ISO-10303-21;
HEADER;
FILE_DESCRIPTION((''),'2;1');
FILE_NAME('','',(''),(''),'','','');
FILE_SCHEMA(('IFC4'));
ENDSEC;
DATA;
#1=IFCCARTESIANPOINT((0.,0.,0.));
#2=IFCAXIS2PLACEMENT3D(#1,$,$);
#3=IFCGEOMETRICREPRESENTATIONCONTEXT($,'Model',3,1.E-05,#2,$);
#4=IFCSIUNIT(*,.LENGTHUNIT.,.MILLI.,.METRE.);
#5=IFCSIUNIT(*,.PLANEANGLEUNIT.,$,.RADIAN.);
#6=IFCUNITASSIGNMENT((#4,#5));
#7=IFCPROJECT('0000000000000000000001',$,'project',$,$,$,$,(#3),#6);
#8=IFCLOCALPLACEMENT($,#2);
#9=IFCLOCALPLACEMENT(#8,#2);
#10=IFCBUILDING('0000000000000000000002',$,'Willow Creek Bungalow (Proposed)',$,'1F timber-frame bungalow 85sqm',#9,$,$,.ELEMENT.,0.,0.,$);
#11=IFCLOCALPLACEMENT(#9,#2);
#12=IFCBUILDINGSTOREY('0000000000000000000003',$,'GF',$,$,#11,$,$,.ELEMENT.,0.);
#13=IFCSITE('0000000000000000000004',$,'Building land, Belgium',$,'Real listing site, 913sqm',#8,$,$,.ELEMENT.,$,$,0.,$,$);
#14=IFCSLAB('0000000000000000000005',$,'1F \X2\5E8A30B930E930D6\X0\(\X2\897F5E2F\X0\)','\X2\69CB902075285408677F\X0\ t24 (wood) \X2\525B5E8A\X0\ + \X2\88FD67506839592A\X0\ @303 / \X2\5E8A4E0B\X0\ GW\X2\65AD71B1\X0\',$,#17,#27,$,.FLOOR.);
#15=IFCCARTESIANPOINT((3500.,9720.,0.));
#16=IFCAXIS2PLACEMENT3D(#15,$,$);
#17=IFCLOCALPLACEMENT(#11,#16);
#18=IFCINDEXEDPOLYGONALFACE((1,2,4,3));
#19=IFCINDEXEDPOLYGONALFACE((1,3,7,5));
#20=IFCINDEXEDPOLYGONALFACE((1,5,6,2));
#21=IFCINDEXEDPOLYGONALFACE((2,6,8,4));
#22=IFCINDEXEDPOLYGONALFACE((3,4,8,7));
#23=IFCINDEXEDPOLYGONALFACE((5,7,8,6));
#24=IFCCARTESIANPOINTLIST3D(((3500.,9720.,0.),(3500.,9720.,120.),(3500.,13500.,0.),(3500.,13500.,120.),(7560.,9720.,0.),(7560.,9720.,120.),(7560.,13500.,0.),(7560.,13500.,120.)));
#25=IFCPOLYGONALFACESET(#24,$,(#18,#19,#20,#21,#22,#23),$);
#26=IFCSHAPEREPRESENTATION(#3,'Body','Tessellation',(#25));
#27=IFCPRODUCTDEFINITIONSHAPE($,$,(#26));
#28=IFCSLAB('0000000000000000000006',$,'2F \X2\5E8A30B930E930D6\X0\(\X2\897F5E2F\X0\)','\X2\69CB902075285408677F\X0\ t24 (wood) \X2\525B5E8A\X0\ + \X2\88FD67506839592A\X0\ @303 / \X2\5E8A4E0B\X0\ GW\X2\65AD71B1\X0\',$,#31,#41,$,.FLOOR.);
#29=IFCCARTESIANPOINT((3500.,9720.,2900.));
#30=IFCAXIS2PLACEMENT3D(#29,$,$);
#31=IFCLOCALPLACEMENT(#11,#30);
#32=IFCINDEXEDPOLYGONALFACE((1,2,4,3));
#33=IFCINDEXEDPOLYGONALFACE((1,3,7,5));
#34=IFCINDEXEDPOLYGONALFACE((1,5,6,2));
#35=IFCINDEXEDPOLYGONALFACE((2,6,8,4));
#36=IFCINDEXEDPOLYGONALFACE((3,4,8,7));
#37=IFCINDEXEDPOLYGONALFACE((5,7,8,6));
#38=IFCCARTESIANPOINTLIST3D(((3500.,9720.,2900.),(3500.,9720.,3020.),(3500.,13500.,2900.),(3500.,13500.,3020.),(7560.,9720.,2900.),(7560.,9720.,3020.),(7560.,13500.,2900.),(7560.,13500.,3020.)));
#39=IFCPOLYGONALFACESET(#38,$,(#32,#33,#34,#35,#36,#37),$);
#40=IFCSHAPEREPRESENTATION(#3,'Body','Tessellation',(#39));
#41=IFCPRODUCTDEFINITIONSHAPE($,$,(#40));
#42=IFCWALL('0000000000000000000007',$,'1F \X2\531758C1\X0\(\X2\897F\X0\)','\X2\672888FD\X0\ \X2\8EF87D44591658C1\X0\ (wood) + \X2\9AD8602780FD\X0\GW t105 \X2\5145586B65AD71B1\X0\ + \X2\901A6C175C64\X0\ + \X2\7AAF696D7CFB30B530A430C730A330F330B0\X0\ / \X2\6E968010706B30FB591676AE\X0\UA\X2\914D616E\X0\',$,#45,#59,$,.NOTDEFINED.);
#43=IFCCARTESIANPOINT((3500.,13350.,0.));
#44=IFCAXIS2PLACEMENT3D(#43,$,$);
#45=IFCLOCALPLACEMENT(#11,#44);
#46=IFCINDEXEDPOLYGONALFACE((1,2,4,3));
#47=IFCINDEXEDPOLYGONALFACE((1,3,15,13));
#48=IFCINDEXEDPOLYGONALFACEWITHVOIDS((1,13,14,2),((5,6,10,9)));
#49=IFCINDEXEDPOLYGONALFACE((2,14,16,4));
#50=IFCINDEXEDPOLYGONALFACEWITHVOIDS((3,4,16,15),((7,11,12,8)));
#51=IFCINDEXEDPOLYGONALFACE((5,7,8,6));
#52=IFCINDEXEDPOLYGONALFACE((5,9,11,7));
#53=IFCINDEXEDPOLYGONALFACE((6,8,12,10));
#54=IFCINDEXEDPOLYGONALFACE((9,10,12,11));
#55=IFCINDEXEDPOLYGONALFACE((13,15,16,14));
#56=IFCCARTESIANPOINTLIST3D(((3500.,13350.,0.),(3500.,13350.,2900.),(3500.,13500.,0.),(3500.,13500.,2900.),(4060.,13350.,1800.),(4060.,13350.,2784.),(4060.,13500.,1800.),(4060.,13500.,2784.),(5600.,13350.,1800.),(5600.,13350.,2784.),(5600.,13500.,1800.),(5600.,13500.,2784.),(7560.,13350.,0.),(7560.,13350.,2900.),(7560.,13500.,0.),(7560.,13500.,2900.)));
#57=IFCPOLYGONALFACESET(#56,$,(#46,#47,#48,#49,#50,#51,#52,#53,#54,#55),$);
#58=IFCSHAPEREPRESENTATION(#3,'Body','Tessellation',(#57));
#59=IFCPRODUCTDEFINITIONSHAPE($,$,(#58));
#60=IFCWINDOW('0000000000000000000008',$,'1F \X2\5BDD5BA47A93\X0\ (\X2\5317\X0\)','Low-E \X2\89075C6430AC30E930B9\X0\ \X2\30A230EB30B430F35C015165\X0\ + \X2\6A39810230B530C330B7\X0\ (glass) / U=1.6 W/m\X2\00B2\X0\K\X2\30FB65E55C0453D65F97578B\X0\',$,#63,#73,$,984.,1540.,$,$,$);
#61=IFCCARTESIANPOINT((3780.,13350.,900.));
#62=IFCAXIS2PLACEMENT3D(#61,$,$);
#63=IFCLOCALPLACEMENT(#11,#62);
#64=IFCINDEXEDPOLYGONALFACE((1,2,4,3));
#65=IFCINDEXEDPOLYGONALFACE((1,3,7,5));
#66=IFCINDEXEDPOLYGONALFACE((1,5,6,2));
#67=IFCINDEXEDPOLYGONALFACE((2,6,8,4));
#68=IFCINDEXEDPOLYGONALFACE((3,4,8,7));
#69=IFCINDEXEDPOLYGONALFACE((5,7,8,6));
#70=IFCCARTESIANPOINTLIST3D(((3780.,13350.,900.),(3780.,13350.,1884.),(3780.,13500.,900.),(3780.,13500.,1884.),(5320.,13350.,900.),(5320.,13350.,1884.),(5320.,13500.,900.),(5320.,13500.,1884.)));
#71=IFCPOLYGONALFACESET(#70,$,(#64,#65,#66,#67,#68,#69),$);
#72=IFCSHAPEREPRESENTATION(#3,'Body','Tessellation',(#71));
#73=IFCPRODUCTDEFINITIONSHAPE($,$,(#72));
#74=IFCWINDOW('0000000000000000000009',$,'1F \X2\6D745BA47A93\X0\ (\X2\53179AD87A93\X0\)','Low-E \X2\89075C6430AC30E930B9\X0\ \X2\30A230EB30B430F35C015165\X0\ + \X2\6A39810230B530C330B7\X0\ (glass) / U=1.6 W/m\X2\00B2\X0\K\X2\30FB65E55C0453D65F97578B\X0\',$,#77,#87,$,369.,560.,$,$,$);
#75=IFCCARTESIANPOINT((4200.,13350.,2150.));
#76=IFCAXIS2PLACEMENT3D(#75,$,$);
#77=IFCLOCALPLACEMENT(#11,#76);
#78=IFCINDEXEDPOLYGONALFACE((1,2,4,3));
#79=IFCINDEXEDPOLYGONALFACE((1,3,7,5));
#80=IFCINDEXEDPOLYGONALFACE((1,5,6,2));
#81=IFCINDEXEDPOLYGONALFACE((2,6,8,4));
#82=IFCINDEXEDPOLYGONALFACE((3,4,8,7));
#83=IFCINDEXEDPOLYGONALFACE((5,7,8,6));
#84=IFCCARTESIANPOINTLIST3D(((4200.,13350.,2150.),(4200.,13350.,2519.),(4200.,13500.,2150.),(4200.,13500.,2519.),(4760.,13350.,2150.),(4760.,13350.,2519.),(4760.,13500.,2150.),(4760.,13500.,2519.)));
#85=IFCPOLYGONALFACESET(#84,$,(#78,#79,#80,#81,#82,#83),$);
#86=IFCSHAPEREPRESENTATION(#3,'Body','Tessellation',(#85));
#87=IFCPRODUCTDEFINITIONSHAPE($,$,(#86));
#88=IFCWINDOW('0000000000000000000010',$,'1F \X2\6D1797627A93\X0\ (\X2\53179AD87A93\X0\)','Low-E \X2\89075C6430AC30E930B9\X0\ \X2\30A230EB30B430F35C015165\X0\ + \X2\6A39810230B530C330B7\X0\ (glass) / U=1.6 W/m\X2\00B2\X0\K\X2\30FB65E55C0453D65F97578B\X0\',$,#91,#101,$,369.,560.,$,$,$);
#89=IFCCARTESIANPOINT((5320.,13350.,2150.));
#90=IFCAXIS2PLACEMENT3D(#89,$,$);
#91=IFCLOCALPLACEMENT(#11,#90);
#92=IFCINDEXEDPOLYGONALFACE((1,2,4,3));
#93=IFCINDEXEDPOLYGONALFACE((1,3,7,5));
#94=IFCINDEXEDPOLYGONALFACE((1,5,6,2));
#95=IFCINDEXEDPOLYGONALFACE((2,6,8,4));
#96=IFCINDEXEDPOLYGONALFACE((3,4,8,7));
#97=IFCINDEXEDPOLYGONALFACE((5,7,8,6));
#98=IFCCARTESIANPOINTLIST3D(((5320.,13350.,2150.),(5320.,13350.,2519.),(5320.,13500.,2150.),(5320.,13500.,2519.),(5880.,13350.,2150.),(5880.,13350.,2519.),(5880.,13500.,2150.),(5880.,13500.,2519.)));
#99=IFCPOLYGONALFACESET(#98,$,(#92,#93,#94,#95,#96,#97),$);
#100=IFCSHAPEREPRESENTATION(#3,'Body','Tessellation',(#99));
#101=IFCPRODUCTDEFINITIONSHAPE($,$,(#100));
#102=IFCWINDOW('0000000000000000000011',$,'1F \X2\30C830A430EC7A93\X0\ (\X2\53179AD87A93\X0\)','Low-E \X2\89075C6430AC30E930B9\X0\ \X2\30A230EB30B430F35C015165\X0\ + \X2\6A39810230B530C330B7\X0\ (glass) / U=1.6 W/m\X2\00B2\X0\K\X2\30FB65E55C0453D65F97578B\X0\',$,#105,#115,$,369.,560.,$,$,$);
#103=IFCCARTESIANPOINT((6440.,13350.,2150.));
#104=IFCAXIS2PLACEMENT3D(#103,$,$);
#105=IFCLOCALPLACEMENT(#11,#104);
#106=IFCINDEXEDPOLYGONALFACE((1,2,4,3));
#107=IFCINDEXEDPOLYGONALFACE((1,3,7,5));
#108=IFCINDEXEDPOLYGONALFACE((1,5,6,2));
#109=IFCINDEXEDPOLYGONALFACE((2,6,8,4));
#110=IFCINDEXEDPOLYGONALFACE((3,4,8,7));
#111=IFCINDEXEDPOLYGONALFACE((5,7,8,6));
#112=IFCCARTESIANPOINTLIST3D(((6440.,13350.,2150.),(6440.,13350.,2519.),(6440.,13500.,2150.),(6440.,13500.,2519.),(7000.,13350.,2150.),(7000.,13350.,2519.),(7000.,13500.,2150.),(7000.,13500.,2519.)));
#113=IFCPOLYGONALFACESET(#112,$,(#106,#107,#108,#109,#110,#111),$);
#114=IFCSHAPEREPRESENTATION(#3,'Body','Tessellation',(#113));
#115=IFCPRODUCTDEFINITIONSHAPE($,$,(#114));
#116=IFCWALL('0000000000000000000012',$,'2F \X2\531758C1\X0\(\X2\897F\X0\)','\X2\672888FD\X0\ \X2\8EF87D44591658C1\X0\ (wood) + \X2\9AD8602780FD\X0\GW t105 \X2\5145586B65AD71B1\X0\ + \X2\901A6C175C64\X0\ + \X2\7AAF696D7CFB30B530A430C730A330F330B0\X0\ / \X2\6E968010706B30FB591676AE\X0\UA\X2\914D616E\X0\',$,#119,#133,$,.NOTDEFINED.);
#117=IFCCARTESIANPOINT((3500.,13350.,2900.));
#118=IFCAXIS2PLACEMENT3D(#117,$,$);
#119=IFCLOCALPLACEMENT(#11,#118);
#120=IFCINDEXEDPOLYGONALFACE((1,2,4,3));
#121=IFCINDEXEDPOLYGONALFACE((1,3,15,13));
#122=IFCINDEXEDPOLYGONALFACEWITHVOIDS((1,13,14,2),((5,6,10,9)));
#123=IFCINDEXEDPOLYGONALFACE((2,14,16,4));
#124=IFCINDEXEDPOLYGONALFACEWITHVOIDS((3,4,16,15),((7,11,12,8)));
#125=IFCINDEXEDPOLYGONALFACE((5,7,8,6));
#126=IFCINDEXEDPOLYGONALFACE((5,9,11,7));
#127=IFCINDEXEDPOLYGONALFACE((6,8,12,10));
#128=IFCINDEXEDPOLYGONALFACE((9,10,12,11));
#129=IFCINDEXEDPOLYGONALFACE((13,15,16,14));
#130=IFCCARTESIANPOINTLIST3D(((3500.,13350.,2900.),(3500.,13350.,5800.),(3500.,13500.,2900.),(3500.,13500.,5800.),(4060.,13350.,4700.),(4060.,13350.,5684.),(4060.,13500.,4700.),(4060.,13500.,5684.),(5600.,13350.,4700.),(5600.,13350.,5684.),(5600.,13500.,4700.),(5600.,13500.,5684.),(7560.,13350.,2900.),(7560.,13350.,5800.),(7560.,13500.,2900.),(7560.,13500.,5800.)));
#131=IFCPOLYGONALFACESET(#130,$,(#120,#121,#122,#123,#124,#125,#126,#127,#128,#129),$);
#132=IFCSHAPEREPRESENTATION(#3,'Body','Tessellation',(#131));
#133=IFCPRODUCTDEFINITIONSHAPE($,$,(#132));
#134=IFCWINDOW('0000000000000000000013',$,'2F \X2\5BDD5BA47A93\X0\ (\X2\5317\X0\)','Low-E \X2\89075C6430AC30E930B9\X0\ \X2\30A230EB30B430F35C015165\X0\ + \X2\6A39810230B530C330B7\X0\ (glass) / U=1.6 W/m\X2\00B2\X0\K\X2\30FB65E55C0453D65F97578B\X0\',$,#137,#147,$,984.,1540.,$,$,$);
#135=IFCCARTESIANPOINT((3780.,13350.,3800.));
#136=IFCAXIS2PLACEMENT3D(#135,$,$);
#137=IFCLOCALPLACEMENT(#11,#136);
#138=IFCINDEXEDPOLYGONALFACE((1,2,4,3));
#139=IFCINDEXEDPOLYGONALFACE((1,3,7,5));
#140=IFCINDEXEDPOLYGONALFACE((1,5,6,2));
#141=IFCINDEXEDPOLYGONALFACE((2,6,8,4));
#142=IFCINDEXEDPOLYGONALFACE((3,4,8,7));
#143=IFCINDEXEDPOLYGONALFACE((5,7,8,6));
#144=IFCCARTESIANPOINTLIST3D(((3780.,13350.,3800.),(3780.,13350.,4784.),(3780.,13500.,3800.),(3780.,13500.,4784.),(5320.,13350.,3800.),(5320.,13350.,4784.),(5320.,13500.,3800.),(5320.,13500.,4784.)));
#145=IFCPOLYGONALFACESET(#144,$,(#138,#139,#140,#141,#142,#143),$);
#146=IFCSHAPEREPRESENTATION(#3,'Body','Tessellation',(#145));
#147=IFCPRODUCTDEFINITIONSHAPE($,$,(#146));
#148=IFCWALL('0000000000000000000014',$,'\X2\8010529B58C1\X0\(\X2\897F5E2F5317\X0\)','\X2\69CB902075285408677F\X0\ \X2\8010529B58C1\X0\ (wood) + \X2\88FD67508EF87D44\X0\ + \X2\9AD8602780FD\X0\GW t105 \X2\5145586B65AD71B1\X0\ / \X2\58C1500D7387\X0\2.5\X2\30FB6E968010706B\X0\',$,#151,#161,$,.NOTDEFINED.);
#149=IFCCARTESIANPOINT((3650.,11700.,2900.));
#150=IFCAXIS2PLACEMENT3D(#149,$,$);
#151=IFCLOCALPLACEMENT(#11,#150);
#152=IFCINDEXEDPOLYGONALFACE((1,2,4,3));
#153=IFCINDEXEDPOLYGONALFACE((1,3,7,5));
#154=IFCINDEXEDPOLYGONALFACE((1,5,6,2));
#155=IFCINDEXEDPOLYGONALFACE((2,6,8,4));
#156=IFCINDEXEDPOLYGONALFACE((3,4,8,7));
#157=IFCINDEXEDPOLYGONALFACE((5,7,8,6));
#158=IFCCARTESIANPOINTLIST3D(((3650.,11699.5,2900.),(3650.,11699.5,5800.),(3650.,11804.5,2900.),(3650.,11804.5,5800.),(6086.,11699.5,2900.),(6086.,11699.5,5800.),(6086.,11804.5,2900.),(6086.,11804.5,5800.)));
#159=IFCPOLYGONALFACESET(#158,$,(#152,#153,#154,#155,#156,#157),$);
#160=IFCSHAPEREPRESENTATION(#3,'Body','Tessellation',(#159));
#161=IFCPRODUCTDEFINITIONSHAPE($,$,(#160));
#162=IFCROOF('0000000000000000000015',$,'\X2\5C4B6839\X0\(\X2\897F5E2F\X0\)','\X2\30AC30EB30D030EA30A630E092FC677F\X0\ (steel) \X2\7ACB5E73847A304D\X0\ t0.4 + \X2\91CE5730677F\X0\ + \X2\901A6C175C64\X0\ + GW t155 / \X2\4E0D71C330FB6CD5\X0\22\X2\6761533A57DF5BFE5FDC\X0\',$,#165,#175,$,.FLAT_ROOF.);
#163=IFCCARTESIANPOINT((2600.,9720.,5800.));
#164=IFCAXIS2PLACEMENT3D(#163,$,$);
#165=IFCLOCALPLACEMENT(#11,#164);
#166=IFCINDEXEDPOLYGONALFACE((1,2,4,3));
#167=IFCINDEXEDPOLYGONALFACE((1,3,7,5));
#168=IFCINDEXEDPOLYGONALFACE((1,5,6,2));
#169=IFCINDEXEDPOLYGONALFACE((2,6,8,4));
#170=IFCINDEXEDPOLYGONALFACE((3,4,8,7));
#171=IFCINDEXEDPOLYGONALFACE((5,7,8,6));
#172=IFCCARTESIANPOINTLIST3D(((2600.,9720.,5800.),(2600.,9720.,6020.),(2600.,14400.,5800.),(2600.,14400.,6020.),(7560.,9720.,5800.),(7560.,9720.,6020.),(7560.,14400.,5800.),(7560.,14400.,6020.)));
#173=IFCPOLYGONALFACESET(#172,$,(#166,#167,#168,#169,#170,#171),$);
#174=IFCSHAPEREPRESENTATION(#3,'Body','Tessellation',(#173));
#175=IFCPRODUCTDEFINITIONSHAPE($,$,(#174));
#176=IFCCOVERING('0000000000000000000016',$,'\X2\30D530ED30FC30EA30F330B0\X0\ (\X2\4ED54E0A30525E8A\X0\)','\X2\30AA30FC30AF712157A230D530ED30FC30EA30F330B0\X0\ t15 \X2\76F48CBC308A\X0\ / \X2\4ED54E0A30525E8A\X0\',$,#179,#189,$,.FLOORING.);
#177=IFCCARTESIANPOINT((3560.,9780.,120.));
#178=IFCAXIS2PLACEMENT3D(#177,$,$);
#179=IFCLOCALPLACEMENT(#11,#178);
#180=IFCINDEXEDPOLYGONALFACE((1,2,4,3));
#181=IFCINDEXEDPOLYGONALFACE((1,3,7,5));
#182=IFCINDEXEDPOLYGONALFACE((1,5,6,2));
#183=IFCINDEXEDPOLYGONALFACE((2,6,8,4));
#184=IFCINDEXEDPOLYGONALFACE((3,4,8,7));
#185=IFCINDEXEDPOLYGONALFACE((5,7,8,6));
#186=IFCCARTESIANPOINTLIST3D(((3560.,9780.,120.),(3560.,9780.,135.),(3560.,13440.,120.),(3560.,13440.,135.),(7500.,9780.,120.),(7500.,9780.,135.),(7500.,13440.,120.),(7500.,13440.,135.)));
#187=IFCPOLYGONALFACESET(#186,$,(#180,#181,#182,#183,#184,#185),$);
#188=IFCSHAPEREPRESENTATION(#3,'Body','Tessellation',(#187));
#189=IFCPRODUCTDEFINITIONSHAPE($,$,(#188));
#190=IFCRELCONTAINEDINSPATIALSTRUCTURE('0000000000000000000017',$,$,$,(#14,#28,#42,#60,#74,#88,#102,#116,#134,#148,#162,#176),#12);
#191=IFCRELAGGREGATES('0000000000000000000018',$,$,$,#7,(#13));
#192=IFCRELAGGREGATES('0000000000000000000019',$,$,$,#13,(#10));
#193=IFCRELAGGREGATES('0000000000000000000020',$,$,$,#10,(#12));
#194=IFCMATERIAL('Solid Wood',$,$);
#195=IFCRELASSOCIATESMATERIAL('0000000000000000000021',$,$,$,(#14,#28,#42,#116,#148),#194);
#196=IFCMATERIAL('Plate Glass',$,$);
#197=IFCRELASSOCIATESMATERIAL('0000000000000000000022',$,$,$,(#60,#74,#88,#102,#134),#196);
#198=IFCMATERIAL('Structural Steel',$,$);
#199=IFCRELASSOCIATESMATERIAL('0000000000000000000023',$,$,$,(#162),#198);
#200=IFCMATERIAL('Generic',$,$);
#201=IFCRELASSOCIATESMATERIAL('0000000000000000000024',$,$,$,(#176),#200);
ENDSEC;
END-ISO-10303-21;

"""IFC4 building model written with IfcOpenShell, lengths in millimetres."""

from ifc_helpers import new_model, si_unit, frame, frame_2d, origin, place, context, project, spatial, rectangle, extrude, material, element, fill, save


model = new_model("IFC4")

# Units and contexts
model_context = context("Model", 3, precision=1e-05, world=origin())
ifc_project = project(units=[si_unit("LENGTHUNIT", "METRE", prefix="MILLI"), si_unit("PLANEANGLEUNIT", "RADIAN")], contexts=[model_context])

# Site, building, storey
site_placement = place(None, origin())
site = spatial("IfcSite", under=ifc_project, at=site_placement, Name="Building land, Belgium", ObjectType="Real listing site, 913sqm", CompositionType="ELEMENT", RefElevation=0.0)
building_placement = place(site_placement, origin())
building = spatial("IfcBuilding", under=site, at=building_placement, Name="Willow Creek Bungalow (Proposed)", ObjectType="1F timber-frame bungalow 85sqm", CompositionType="ELEMENT", ElevationOfRefHeight=0.0, ElevationOfTerrain=0.0)
storey_placement = place(building_placement, origin())
storey = spatial("IfcBuildingStorey", under=building, at=storey_placement, Name="GF", CompositionType="ELEMENT", Elevation=0.0)

# Slabs
ifc_material_1 = material(Name="Solid Wood")
slab_1_placement = place(storey_placement, frame((3500.0, 9720.0, 0.0)))
element("IfcSlab", 1, at=slab_1_placement, inside=storey, material=ifc_material_1, Name="1F 床スラブ(西帯)", Description="構造用合板 t24 (wood) 剛床 + 製材根太 @303 / 床下 GW断熱", PredefinedType="FLOOR", context=model_context, shape_type="SweptSolid", body=[
    extrude(rectangle(XDim=4060.0, YDim=3780.0, at=frame_2d((2030.0, 1890.0))), frame((3500.0, 9720.0, 0.0)), (0.0, 0.0, 1.0), 120.0),
])
slab_2_placement = place(storey_placement, frame((3500.0, 9720.0, 2900.0)))
element("IfcSlab", 2, at=slab_2_placement, inside=storey, material=ifc_material_1, Name="2F 床スラブ(西帯)", Description="構造用合板 t24 (wood) 剛床 + 製材根太 @303 / 床下 GW断熱", PredefinedType="FLOOR", context=model_context, shape_type="SweptSolid", body=[
    extrude(rectangle(XDim=4060.0, YDim=3780.0, at=frame_2d((2030.0, 1890.0))), frame((3500.0, 9720.0, 2900.0)), (0.0, 0.0, 1.0), 120.0),
])

# Wall, openings, windows
wall_1_placement = place(storey_placement, frame((3500.0, 13350.0, 0.0)))
wall_1 = element("IfcWall", 3, at=wall_1_placement, inside=storey, material=ifc_material_1, Name="1F 北壁(西)", Description="木製 軸組外壁 (wood) + 高性能GW t105 充填断熱 + 通気層 + 窯業系サイディング / 準耐火・外皮UA配慮", PredefinedType="NOTDEFINED", context=model_context, shape_type="SweptSolid", body=[
    extrude(rectangle(XDim=4060.0, YDim=150.0, at=frame_2d((2030.0, 75.0))), frame((3500.0, 13350.0, 0.0)), (0.0, 0.0, 1.0), 2900.0),
])
opening_1_placement = place(storey_placement, frame((3780.0, 13350.0, 900.0)))
opening_1 = element("IfcOpeningElement", 4, at=opening_1_placement, cuts=wall_1, PredefinedType="NOTDEFINED", context=model_context, shape_type="SweptSolid", body=[
    extrude(rectangle(XDim=1540.0, YDim=150.0, at=frame_2d((770.0, 75.0))), frame((3780.0, 13350.0, 900.0)), (0.0, 0.0, 1.0), 984.0),
])
opening_2_placement = place(storey_placement, frame((4200.0, 13350.0, 2150.0)))
opening_2 = element("IfcOpeningElement", 5, at=opening_2_placement, cuts=wall_1, PredefinedType="NOTDEFINED", context=model_context, shape_type="SweptSolid", body=[
    extrude(rectangle(XDim=560.0, YDim=150.0, at=frame_2d((280.0, 75.0))), frame((4200.0, 13350.0, 2150.0)), (0.0, 0.0, 1.0), 369.0),
])
opening_3_placement = place(storey_placement, frame((5320.0, 13350.0, 2150.0)))
opening_3 = element("IfcOpeningElement", 6, at=opening_3_placement, cuts=wall_1, PredefinedType="NOTDEFINED", context=model_context, shape_type="SweptSolid", body=[
    extrude(rectangle(XDim=560.0, YDim=150.0, at=frame_2d((280.0, 75.0))), frame((5320.0, 13350.0, 2150.0)), (0.0, 0.0, 1.0), 369.0),
])
opening_4_placement = place(storey_placement, frame((6440.0, 13350.0, 2150.0)))
opening_4 = element("IfcOpeningElement", 7, at=opening_4_placement, cuts=wall_1, PredefinedType="NOTDEFINED", context=model_context, shape_type="SweptSolid", body=[
    extrude(rectangle(XDim=560.0, YDim=150.0, at=frame_2d((280.0, 75.0))), frame((6440.0, 13350.0, 2150.0)), (0.0, 0.0, 1.0), 369.0),
])
ifc_material_2 = material(Name="Plate Glass")
window_1_placement = place(storey_placement, frame((3780.0, 13350.0, 900.0)))
window_1 = element("IfcWindow", 8, at=window_1_placement, inside=storey, material=ifc_material_2, Name="1F 寝室窓 (北)", Description="Low-E 複層ガラス アルゴン封入 + 樹脂サッシ (glass) / U=1.6 W/m²K・日射取得型", OverallHeight=984.0, OverallWidth=1540.0, context=model_context, shape_type="SweptSolid", body=[
    extrude(rectangle(XDim=1540.0, YDim=150.0, at=frame_2d((770.0, 75.0))), frame((3780.0, 13350.0, 900.0)), (0.0, 0.0, 1.0), 984.0),
])
fill(opening_1, window_1)
window_2_placement = place(storey_placement, frame((4200.0, 13350.0, 2150.0)))
window_2 = element("IfcWindow", 9, at=window_2_placement, inside=storey, material=ifc_material_2, Name="1F 浴室窓 (北高窓)", Description="Low-E 複層ガラス アルゴン封入 + 樹脂サッシ (glass) / U=1.6 W/m²K・日射取得型", OverallHeight=369.0, OverallWidth=560.0, context=model_context, shape_type="SweptSolid", body=[
    extrude(rectangle(XDim=560.0, YDim=150.0, at=frame_2d((280.0, 75.0))), frame((4200.0, 13350.0, 2150.0)), (0.0, 0.0, 1.0), 369.0),
])
fill(opening_2, window_2)
window_3_placement = place(storey_placement, frame((5320.0, 13350.0, 2150.0)))
window_3 = element("IfcWindow", 10, at=window_3_placement, inside=storey, material=ifc_material_2, Name="1F 洗面窓 (北高窓)", Description="Low-E 複層ガラス アルゴン封入 + 樹脂サッシ (glass) / U=1.6 W/m²K・日射取得型", OverallHeight=369.0, OverallWidth=560.0, context=model_context, shape_type="SweptSolid", body=[
    extrude(rectangle(XDim=560.0, YDim=150.0, at=frame_2d((280.0, 75.0))), frame((5320.0, 13350.0, 2150.0)), (0.0, 0.0, 1.0), 369.0),
])
fill(opening_3, window_3)
window_4_placement = place(storey_placement, frame((6440.0, 13350.0, 2150.0)))
window_4 = element("IfcWindow", 11, at=window_4_placement, inside=storey, material=ifc_material_2, Name="1F トイレ窓 (北高窓)", Description="Low-E 複層ガラス アルゴン封入 + 樹脂サッシ (glass) / U=1.6 W/m²K・日射取得型", OverallHeight=369.0, OverallWidth=560.0, context=model_context, shape_type="SweptSolid", body=[
    extrude(rectangle(XDim=560.0, YDim=150.0, at=frame_2d((280.0, 75.0))), frame((6440.0, 13350.0, 2150.0)), (0.0, 0.0, 1.0), 369.0),
])
fill(opening_4, window_4)

# Wall, opening, window
wall_2_placement = place(storey_placement, frame((3500.0, 13350.0, 2900.0)))
wall_2 = element("IfcWall", 12, at=wall_2_placement, inside=storey, material=ifc_material_1, Name="2F 北壁(西)", Description="木製 軸組外壁 (wood) + 高性能GW t105 充填断熱 + 通気層 + 窯業系サイディング / 準耐火・外皮UA配慮", PredefinedType="NOTDEFINED", context=model_context, shape_type="SweptSolid", body=[
    extrude(rectangle(XDim=4060.0, YDim=150.0, at=frame_2d((2030.0, 75.0))), frame((3500.0, 13350.0, 2900.0)), (0.0, 0.0, 1.0), 2900.0),
])
opening_5_placement = place(storey_placement, frame((3780.0, 13350.0, 3800.0)))
opening_5 = element("IfcOpeningElement", 13, at=opening_5_placement, cuts=wall_2, PredefinedType="NOTDEFINED", context=model_context, shape_type="SweptSolid", body=[
    extrude(rectangle(XDim=1540.0, YDim=150.0, at=frame_2d((770.0, 75.0))), frame((3780.0, 13350.0, 3800.0)), (0.0, 0.0, 1.0), 984.0),
])
window_5_placement = place(storey_placement, frame((3780.0, 13350.0, 3800.0)))
window_5 = element("IfcWindow", 14, at=window_5_placement, inside=storey, material=ifc_material_2, Name="2F 寝室窓 (北)", Description="Low-E 複層ガラス アルゴン封入 + 樹脂サッシ (glass) / U=1.6 W/m²K・日射取得型", OverallHeight=984.0, OverallWidth=1540.0, context=model_context, shape_type="SweptSolid", body=[
    extrude(rectangle(XDim=1540.0, YDim=150.0, at=frame_2d((770.0, 75.0))), frame((3780.0, 13350.0, 3800.0)), (0.0, 0.0, 1.0), 984.0),
])
fill(opening_5, window_5)

# Wall
wall_3_placement = place(storey_placement, frame((3650.0, 11700.0, 2900.0)))
element("IfcWall", 15, at=wall_3_placement, inside=storey, material=ifc_material_1, Name="耐力壁(西帯北)", Description="構造用合板 耐力壁 (wood) + 製材軸組 + 高性能GW t105 充填断熱 / 壁倍率2.5・準耐火", PredefinedType="NOTDEFINED", context=model_context, shape_type="SweptSolid", body=[
    extrude(rectangle(XDim=2436.0, YDim=105.0, at=frame_2d((1218.0, 52.0))), frame((3650.0, 11700.0, 2900.0)), (0.0, 0.0, 1.0), 2900.0),
])

# Roof
ifc_material_3 = material(Name="Structural Steel")
for number, where, name in (
    (16, (2600.0, 9720.0, 5800.0), "屋根(西帯)"),
):
    element("IfcRoof", number, at=place(storey_placement, frame(where)), inside=storey, material=ifc_material_3, Name=name, Description="ガルバリウム鋼板 (steel) 立平葺き t0.4 + 野地板 + 通気層 + GW t155 / 不燃・法22条区域対応", PredefinedType="FLAT_ROOF", context=model_context, shape_type="SweptSolid", body=[
        extrude(rectangle(XDim=4960.0, YDim=4680.0, at=frame_2d((2480.0, 2340.0))), frame((2600.0, 9720.0, 5800.0)), (0.0, 0.0, 1.0), 220.0),
    ])

# Covering
ifc_material_4 = material(Name="Generic")
covering_1_placement = place(storey_placement, frame((3560.0, 9780.0, 120.0)))
element("IfcCovering", 17, at=covering_1_placement, inside=storey, material=ifc_material_4, Name="フローリング (仕上げ床)", Description="オーク無垢フローリング t15 直貼り / 仕上げ床", PredefinedType="FLOORING", context=model_context, shape_type="SweptSolid", body=[
    extrude(rectangle(XDim=3940.0, YDim=3660.0, at=frame_2d((1970.0, 1830.0))), frame((3560.0, 9780.0, 120.0)), (0.0, 0.0, 1.0), 15.0),
])

save(model, "model.ifc")
